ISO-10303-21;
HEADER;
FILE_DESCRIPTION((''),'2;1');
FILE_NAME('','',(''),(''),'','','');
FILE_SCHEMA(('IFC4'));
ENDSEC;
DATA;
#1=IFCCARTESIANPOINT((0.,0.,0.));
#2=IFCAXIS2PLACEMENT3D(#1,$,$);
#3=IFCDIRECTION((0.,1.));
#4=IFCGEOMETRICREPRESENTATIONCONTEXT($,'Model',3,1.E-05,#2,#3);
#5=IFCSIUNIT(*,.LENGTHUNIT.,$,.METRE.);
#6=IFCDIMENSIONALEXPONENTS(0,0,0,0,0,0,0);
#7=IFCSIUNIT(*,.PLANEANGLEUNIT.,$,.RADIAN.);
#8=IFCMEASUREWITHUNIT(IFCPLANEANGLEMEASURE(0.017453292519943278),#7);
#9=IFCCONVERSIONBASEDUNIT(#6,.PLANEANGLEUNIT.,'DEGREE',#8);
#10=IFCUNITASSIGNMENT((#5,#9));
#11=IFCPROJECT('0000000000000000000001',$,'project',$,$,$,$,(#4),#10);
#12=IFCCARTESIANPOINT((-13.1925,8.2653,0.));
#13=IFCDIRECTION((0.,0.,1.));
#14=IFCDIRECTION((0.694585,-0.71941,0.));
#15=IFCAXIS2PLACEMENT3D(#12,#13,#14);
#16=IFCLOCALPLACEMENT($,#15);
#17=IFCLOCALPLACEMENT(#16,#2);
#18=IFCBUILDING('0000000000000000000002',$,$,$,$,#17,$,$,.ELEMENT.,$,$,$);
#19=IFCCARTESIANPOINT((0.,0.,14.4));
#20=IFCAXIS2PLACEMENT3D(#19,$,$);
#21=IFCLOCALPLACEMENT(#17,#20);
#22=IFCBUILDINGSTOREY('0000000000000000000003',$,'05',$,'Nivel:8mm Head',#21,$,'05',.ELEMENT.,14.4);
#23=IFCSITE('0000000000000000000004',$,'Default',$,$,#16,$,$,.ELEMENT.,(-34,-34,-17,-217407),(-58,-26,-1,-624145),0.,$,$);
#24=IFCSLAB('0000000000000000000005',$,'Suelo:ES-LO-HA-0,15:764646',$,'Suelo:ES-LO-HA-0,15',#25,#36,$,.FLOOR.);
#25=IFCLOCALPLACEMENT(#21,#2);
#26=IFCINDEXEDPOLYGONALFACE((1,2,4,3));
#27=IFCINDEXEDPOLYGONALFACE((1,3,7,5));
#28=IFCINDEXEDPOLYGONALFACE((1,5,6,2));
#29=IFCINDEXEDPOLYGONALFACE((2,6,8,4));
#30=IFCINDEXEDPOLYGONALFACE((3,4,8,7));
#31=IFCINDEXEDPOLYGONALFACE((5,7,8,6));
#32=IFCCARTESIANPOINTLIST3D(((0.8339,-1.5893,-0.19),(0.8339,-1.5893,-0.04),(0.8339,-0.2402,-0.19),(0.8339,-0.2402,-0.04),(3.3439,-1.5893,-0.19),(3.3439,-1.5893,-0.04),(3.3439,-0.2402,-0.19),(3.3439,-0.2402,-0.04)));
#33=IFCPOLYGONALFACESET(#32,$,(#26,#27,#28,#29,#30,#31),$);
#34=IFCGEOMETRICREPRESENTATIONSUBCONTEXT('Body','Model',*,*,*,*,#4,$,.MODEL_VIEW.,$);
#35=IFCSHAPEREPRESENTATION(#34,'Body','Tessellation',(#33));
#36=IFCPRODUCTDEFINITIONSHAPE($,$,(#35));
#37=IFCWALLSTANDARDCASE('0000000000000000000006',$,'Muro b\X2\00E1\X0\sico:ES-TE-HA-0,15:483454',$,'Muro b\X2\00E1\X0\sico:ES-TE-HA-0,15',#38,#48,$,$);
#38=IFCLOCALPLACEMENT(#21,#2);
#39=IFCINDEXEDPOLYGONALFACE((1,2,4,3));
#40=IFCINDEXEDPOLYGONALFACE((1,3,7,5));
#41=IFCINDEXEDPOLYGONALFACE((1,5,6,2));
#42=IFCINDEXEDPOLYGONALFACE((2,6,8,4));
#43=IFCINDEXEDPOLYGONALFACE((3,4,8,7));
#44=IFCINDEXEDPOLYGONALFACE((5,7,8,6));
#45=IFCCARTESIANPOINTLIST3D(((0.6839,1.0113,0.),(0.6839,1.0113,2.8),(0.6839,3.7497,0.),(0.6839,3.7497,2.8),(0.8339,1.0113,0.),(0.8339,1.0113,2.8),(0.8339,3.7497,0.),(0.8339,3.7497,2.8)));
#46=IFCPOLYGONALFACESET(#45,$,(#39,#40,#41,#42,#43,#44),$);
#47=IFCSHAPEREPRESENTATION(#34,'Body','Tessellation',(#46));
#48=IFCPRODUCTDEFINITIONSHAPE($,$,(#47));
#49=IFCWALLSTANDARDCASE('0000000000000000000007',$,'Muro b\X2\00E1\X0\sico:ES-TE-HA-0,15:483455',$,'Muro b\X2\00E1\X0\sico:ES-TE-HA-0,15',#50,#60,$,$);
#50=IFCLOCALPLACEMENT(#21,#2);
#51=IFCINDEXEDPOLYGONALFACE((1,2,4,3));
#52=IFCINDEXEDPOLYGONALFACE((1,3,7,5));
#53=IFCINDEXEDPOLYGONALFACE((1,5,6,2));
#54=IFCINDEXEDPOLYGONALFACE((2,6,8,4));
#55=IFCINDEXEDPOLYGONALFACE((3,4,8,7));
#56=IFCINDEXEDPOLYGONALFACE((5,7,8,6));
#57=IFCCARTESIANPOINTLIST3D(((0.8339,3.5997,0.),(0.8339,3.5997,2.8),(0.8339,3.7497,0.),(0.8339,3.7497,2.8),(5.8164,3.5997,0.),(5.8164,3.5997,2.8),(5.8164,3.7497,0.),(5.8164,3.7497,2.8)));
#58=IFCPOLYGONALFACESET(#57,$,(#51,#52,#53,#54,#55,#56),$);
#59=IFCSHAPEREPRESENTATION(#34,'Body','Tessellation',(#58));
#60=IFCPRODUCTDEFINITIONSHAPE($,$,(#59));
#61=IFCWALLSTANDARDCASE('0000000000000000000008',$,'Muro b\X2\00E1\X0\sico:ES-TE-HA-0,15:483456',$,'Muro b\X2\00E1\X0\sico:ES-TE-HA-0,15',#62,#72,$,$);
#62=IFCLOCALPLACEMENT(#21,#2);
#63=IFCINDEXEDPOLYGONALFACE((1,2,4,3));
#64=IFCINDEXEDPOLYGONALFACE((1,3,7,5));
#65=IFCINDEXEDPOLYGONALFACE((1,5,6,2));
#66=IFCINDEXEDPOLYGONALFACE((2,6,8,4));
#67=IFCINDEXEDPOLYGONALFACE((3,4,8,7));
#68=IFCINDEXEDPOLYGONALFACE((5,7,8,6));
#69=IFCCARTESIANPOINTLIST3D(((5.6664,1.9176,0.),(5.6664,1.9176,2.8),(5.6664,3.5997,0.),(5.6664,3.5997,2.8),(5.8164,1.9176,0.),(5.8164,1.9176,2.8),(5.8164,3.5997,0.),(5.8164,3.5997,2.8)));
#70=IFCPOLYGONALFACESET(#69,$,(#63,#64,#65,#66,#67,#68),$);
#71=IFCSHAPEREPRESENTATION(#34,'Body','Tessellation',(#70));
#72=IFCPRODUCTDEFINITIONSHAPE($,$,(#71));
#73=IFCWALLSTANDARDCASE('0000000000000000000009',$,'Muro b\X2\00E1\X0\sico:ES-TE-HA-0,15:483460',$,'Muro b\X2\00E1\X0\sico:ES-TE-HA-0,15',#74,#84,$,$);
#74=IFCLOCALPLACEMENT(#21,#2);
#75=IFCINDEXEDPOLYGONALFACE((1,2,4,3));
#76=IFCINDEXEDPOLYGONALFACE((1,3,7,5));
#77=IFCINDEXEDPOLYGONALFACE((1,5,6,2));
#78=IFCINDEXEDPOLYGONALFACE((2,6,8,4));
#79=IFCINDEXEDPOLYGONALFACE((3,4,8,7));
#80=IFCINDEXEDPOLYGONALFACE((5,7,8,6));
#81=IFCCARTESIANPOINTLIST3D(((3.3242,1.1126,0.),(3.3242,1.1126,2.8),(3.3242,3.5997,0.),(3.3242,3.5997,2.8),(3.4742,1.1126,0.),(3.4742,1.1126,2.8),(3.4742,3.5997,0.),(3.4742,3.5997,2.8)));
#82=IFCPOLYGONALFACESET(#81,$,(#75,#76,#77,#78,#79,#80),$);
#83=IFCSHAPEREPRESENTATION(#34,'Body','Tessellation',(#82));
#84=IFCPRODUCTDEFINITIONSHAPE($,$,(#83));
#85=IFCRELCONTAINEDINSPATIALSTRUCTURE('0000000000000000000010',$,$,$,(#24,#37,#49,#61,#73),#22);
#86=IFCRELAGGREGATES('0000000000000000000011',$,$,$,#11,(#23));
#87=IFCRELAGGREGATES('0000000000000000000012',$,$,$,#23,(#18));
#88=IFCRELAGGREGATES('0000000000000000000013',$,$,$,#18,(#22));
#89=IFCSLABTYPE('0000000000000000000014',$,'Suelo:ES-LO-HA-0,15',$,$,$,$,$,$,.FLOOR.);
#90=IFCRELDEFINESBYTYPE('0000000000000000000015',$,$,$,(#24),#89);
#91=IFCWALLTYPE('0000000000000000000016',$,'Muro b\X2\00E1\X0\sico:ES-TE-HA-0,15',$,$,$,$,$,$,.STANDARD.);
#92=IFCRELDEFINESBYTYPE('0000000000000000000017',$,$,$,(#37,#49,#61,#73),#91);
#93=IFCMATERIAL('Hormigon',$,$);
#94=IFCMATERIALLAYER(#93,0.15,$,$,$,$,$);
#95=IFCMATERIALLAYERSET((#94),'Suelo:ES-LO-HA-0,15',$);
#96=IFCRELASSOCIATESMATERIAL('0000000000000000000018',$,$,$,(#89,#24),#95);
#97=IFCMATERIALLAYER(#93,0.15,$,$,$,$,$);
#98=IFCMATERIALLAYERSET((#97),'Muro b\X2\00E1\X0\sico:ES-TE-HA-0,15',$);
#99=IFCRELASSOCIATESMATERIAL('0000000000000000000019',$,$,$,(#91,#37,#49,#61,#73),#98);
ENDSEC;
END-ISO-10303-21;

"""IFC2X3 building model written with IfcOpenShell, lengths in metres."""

from ifc_helpers import new_model, entity, si_unit, converted_unit, direction, frame, frame_2d, origin, origin_2d_with_axis, place, context, subcontext, project, spatial, rectangle, extrude, material, layer, layer_set, layer_usage, type_object, element, save


model = new_model("IFC2X3")

# Units and contexts
model_context = context("Model", 3, precision=1e-05, world=origin(), true_north=direction((0.0, 1.0)))
body_context = subcontext(model_context, "Body", "Model", "MODEL_VIEW")
ifc_project = project(units=[si_unit("LENGTHUNIT", "METRE"), converted_unit("PLANEANGLEUNIT", "DEGREE", entity("IfcPlaneAngleMeasure", 0.017453292519943278), si_unit("PLANEANGLEUNIT", "RADIAN"), dimensions=[0, 0, 0, 0, 0, 0, 0])], contexts=[model_context])

# Site, building, storey
site_placement = place(None, frame((-13.1925, 8.2653, 0.0), z_axis=(0.0, 0.0, 1.0), x_axis=(0.694585, -0.71941, 0.0)))
site = spatial("IfcSite", under=ifc_project, at=site_placement, Name="Default", CompositionType="ELEMENT", RefLatitude=(-34, -34, -17, -217407), RefLongitude=(-58, -26, -1, -624145), RefElevation=0.0)
building_placement = place(site_placement, origin())
building = spatial("IfcBuilding", under=site, at=building_placement, CompositionType="ELEMENT")
storey_placement = place(building_placement, frame((0.0, 0.0, 14.4)))
storey = spatial("IfcBuildingStorey", under=building, at=storey_placement, Name="05", ObjectType="Nivel:8mm Head", LongName="05", CompositionType="ELEMENT", Elevation=14.4)

# Slab
ifc_material_1 = material(Name="Hormigon")
ifc_layer_1 = layer(ifc_material_1, 0.15)
ifc_layer_set_1 = layer_set([ifc_layer_1], Name="Suelo:ES-LO-HA-0,15")
ifc_layer_usage_1 = layer_usage(ifc_layer_set_1, "AXIS3", "POSITIVE", 0.0)
slab_type_1 = type_object("IfcSlabType", Name="Suelo:ES-LO-HA-0,15", PredefinedType="FLOOR", material=ifc_layer_set_1)
slab_1_placement = place(storey_placement, origin())
element("IfcSlab", 1, at=slab_1_placement, inside=storey, type_object=slab_type_1, material=ifc_layer_usage_1, Name="Suelo:ES-LO-HA-0,15:764646", ObjectType="Suelo:ES-LO-HA-0,15", PredefinedType="FLOOR", context=body_context, shape_type="SweptSolid", body=[
    extrude(rectangle(XDim=1.3491, YDim=2.51, at=origin_2d_with_axis()), frame((2.0889, -0.9147, -0.04), z_axis=(0.0, 0.0, -1.0), x_axis=(0.0, 1.0, 0.0)), (0.0, 0.0, 1.0), 0.15),
])

# Walls
ifc_layer_2 = layer(ifc_material_1, 0.15)
ifc_layer_set_2 = layer_set([ifc_layer_2], Name="Muro básico:ES-TE-HA-0,15")
ifc_layer_usage_2 = layer_usage(ifc_layer_set_2, "AXIS2", "NEGATIVE", 0.075)
wall_type = type_object("IfcWallType", Name="Muro básico:ES-TE-HA-0,15", PredefinedType="STANDARD", material=ifc_layer_set_2)
wall_1_placement = place(storey_placement, frame((0.7589, 1.0113, 0.0), z_axis=(0.0, 0.0, 1.0), x_axis=(0.0, 1.0, 0.0)))
element("IfcWallStandardCase", 2, at=wall_1_placement, inside=storey, type_object=wall_type, material=ifc_layer_usage_2, Name="Muro básico:ES-TE-HA-0,15:483454", ObjectType="Muro básico:ES-TE-HA-0,15", context=body_context, shape_type="SweptSolid", body=[
    extrude(rectangle(XDim=2.7384, YDim=0.15, at=frame_2d((1.3692, 0.0), x_axis=(-1.0, 0.0))), origin(), (0.0, 0.0, 1.0), 2.8),
])
ifc_layer_usage_3 = layer_usage(ifc_layer_set_2, "AXIS2", "NEGATIVE", 0.075)
wall_2_placement = place(storey_placement, frame((0.8339, 3.6747, 0.0)))
element("IfcWallStandardCase", 3, at=wall_2_placement, inside=storey, type_object=wall_type, material=ifc_layer_usage_3, Name="Muro básico:ES-TE-HA-0,15:483455", ObjectType="Muro básico:ES-TE-HA-0,15", context=body_context, shape_type="SweptSolid", body=[
    extrude(rectangle(XDim=4.9825, YDim=0.15, at=frame_2d((2.4912, 0.0), x_axis=(-1.0, 0.0))), origin(), (0.0, 0.0, 1.0), 2.8),
])
ifc_layer_usage_4 = layer_usage(ifc_layer_set_2, "AXIS2", "NEGATIVE", 0.075)
wall_3_placement = place(storey_placement, frame((5.7414, 1.9176, 0.0), z_axis=(0.0, 0.0, 1.0), x_axis=(0.0, 1.0, 0.0)))
element("IfcWallStandardCase", 4, at=wall_3_placement, inside=storey, type_object=wall_type, material=ifc_layer_usage_4, Name="Muro básico:ES-TE-HA-0,15:483456", ObjectType="Muro básico:ES-TE-HA-0,15", context=body_context, shape_type="SweptSolid", body=[
    extrude(rectangle(XDim=1.682, YDim=0.15, at=frame_2d((0.841, 0.0), x_axis=(-1.0, 0.0))), origin(), (0.0, 0.0, 1.0), 2.8),
])
ifc_layer_usage_5 = layer_usage(ifc_layer_set_2, "AXIS2", "NEGATIVE", 0.075)
wall_4_placement = place(storey_placement, frame((3.3992, 3.5997, 0.0), z_axis=(0.0, 0.0, 1.0), x_axis=(0.0, -1.0, 0.0)))
element("IfcWallStandardCase", 5, at=wall_4_placement, inside=storey, type_object=wall_type, material=ifc_layer_usage_5, Name="Muro básico:ES-TE-HA-0,15:483460", ObjectType="Muro básico:ES-TE-HA-0,15", context=body_context, shape_type="SweptSolid", body=[
    extrude(rectangle(XDim=2.487, YDim=0.15, at=frame_2d((1.2435, 0.0), x_axis=(-1.0, 0.0))), origin(), (0.0, 0.0, 1.0), 2.8),
])

save(model, "model.ifc")
